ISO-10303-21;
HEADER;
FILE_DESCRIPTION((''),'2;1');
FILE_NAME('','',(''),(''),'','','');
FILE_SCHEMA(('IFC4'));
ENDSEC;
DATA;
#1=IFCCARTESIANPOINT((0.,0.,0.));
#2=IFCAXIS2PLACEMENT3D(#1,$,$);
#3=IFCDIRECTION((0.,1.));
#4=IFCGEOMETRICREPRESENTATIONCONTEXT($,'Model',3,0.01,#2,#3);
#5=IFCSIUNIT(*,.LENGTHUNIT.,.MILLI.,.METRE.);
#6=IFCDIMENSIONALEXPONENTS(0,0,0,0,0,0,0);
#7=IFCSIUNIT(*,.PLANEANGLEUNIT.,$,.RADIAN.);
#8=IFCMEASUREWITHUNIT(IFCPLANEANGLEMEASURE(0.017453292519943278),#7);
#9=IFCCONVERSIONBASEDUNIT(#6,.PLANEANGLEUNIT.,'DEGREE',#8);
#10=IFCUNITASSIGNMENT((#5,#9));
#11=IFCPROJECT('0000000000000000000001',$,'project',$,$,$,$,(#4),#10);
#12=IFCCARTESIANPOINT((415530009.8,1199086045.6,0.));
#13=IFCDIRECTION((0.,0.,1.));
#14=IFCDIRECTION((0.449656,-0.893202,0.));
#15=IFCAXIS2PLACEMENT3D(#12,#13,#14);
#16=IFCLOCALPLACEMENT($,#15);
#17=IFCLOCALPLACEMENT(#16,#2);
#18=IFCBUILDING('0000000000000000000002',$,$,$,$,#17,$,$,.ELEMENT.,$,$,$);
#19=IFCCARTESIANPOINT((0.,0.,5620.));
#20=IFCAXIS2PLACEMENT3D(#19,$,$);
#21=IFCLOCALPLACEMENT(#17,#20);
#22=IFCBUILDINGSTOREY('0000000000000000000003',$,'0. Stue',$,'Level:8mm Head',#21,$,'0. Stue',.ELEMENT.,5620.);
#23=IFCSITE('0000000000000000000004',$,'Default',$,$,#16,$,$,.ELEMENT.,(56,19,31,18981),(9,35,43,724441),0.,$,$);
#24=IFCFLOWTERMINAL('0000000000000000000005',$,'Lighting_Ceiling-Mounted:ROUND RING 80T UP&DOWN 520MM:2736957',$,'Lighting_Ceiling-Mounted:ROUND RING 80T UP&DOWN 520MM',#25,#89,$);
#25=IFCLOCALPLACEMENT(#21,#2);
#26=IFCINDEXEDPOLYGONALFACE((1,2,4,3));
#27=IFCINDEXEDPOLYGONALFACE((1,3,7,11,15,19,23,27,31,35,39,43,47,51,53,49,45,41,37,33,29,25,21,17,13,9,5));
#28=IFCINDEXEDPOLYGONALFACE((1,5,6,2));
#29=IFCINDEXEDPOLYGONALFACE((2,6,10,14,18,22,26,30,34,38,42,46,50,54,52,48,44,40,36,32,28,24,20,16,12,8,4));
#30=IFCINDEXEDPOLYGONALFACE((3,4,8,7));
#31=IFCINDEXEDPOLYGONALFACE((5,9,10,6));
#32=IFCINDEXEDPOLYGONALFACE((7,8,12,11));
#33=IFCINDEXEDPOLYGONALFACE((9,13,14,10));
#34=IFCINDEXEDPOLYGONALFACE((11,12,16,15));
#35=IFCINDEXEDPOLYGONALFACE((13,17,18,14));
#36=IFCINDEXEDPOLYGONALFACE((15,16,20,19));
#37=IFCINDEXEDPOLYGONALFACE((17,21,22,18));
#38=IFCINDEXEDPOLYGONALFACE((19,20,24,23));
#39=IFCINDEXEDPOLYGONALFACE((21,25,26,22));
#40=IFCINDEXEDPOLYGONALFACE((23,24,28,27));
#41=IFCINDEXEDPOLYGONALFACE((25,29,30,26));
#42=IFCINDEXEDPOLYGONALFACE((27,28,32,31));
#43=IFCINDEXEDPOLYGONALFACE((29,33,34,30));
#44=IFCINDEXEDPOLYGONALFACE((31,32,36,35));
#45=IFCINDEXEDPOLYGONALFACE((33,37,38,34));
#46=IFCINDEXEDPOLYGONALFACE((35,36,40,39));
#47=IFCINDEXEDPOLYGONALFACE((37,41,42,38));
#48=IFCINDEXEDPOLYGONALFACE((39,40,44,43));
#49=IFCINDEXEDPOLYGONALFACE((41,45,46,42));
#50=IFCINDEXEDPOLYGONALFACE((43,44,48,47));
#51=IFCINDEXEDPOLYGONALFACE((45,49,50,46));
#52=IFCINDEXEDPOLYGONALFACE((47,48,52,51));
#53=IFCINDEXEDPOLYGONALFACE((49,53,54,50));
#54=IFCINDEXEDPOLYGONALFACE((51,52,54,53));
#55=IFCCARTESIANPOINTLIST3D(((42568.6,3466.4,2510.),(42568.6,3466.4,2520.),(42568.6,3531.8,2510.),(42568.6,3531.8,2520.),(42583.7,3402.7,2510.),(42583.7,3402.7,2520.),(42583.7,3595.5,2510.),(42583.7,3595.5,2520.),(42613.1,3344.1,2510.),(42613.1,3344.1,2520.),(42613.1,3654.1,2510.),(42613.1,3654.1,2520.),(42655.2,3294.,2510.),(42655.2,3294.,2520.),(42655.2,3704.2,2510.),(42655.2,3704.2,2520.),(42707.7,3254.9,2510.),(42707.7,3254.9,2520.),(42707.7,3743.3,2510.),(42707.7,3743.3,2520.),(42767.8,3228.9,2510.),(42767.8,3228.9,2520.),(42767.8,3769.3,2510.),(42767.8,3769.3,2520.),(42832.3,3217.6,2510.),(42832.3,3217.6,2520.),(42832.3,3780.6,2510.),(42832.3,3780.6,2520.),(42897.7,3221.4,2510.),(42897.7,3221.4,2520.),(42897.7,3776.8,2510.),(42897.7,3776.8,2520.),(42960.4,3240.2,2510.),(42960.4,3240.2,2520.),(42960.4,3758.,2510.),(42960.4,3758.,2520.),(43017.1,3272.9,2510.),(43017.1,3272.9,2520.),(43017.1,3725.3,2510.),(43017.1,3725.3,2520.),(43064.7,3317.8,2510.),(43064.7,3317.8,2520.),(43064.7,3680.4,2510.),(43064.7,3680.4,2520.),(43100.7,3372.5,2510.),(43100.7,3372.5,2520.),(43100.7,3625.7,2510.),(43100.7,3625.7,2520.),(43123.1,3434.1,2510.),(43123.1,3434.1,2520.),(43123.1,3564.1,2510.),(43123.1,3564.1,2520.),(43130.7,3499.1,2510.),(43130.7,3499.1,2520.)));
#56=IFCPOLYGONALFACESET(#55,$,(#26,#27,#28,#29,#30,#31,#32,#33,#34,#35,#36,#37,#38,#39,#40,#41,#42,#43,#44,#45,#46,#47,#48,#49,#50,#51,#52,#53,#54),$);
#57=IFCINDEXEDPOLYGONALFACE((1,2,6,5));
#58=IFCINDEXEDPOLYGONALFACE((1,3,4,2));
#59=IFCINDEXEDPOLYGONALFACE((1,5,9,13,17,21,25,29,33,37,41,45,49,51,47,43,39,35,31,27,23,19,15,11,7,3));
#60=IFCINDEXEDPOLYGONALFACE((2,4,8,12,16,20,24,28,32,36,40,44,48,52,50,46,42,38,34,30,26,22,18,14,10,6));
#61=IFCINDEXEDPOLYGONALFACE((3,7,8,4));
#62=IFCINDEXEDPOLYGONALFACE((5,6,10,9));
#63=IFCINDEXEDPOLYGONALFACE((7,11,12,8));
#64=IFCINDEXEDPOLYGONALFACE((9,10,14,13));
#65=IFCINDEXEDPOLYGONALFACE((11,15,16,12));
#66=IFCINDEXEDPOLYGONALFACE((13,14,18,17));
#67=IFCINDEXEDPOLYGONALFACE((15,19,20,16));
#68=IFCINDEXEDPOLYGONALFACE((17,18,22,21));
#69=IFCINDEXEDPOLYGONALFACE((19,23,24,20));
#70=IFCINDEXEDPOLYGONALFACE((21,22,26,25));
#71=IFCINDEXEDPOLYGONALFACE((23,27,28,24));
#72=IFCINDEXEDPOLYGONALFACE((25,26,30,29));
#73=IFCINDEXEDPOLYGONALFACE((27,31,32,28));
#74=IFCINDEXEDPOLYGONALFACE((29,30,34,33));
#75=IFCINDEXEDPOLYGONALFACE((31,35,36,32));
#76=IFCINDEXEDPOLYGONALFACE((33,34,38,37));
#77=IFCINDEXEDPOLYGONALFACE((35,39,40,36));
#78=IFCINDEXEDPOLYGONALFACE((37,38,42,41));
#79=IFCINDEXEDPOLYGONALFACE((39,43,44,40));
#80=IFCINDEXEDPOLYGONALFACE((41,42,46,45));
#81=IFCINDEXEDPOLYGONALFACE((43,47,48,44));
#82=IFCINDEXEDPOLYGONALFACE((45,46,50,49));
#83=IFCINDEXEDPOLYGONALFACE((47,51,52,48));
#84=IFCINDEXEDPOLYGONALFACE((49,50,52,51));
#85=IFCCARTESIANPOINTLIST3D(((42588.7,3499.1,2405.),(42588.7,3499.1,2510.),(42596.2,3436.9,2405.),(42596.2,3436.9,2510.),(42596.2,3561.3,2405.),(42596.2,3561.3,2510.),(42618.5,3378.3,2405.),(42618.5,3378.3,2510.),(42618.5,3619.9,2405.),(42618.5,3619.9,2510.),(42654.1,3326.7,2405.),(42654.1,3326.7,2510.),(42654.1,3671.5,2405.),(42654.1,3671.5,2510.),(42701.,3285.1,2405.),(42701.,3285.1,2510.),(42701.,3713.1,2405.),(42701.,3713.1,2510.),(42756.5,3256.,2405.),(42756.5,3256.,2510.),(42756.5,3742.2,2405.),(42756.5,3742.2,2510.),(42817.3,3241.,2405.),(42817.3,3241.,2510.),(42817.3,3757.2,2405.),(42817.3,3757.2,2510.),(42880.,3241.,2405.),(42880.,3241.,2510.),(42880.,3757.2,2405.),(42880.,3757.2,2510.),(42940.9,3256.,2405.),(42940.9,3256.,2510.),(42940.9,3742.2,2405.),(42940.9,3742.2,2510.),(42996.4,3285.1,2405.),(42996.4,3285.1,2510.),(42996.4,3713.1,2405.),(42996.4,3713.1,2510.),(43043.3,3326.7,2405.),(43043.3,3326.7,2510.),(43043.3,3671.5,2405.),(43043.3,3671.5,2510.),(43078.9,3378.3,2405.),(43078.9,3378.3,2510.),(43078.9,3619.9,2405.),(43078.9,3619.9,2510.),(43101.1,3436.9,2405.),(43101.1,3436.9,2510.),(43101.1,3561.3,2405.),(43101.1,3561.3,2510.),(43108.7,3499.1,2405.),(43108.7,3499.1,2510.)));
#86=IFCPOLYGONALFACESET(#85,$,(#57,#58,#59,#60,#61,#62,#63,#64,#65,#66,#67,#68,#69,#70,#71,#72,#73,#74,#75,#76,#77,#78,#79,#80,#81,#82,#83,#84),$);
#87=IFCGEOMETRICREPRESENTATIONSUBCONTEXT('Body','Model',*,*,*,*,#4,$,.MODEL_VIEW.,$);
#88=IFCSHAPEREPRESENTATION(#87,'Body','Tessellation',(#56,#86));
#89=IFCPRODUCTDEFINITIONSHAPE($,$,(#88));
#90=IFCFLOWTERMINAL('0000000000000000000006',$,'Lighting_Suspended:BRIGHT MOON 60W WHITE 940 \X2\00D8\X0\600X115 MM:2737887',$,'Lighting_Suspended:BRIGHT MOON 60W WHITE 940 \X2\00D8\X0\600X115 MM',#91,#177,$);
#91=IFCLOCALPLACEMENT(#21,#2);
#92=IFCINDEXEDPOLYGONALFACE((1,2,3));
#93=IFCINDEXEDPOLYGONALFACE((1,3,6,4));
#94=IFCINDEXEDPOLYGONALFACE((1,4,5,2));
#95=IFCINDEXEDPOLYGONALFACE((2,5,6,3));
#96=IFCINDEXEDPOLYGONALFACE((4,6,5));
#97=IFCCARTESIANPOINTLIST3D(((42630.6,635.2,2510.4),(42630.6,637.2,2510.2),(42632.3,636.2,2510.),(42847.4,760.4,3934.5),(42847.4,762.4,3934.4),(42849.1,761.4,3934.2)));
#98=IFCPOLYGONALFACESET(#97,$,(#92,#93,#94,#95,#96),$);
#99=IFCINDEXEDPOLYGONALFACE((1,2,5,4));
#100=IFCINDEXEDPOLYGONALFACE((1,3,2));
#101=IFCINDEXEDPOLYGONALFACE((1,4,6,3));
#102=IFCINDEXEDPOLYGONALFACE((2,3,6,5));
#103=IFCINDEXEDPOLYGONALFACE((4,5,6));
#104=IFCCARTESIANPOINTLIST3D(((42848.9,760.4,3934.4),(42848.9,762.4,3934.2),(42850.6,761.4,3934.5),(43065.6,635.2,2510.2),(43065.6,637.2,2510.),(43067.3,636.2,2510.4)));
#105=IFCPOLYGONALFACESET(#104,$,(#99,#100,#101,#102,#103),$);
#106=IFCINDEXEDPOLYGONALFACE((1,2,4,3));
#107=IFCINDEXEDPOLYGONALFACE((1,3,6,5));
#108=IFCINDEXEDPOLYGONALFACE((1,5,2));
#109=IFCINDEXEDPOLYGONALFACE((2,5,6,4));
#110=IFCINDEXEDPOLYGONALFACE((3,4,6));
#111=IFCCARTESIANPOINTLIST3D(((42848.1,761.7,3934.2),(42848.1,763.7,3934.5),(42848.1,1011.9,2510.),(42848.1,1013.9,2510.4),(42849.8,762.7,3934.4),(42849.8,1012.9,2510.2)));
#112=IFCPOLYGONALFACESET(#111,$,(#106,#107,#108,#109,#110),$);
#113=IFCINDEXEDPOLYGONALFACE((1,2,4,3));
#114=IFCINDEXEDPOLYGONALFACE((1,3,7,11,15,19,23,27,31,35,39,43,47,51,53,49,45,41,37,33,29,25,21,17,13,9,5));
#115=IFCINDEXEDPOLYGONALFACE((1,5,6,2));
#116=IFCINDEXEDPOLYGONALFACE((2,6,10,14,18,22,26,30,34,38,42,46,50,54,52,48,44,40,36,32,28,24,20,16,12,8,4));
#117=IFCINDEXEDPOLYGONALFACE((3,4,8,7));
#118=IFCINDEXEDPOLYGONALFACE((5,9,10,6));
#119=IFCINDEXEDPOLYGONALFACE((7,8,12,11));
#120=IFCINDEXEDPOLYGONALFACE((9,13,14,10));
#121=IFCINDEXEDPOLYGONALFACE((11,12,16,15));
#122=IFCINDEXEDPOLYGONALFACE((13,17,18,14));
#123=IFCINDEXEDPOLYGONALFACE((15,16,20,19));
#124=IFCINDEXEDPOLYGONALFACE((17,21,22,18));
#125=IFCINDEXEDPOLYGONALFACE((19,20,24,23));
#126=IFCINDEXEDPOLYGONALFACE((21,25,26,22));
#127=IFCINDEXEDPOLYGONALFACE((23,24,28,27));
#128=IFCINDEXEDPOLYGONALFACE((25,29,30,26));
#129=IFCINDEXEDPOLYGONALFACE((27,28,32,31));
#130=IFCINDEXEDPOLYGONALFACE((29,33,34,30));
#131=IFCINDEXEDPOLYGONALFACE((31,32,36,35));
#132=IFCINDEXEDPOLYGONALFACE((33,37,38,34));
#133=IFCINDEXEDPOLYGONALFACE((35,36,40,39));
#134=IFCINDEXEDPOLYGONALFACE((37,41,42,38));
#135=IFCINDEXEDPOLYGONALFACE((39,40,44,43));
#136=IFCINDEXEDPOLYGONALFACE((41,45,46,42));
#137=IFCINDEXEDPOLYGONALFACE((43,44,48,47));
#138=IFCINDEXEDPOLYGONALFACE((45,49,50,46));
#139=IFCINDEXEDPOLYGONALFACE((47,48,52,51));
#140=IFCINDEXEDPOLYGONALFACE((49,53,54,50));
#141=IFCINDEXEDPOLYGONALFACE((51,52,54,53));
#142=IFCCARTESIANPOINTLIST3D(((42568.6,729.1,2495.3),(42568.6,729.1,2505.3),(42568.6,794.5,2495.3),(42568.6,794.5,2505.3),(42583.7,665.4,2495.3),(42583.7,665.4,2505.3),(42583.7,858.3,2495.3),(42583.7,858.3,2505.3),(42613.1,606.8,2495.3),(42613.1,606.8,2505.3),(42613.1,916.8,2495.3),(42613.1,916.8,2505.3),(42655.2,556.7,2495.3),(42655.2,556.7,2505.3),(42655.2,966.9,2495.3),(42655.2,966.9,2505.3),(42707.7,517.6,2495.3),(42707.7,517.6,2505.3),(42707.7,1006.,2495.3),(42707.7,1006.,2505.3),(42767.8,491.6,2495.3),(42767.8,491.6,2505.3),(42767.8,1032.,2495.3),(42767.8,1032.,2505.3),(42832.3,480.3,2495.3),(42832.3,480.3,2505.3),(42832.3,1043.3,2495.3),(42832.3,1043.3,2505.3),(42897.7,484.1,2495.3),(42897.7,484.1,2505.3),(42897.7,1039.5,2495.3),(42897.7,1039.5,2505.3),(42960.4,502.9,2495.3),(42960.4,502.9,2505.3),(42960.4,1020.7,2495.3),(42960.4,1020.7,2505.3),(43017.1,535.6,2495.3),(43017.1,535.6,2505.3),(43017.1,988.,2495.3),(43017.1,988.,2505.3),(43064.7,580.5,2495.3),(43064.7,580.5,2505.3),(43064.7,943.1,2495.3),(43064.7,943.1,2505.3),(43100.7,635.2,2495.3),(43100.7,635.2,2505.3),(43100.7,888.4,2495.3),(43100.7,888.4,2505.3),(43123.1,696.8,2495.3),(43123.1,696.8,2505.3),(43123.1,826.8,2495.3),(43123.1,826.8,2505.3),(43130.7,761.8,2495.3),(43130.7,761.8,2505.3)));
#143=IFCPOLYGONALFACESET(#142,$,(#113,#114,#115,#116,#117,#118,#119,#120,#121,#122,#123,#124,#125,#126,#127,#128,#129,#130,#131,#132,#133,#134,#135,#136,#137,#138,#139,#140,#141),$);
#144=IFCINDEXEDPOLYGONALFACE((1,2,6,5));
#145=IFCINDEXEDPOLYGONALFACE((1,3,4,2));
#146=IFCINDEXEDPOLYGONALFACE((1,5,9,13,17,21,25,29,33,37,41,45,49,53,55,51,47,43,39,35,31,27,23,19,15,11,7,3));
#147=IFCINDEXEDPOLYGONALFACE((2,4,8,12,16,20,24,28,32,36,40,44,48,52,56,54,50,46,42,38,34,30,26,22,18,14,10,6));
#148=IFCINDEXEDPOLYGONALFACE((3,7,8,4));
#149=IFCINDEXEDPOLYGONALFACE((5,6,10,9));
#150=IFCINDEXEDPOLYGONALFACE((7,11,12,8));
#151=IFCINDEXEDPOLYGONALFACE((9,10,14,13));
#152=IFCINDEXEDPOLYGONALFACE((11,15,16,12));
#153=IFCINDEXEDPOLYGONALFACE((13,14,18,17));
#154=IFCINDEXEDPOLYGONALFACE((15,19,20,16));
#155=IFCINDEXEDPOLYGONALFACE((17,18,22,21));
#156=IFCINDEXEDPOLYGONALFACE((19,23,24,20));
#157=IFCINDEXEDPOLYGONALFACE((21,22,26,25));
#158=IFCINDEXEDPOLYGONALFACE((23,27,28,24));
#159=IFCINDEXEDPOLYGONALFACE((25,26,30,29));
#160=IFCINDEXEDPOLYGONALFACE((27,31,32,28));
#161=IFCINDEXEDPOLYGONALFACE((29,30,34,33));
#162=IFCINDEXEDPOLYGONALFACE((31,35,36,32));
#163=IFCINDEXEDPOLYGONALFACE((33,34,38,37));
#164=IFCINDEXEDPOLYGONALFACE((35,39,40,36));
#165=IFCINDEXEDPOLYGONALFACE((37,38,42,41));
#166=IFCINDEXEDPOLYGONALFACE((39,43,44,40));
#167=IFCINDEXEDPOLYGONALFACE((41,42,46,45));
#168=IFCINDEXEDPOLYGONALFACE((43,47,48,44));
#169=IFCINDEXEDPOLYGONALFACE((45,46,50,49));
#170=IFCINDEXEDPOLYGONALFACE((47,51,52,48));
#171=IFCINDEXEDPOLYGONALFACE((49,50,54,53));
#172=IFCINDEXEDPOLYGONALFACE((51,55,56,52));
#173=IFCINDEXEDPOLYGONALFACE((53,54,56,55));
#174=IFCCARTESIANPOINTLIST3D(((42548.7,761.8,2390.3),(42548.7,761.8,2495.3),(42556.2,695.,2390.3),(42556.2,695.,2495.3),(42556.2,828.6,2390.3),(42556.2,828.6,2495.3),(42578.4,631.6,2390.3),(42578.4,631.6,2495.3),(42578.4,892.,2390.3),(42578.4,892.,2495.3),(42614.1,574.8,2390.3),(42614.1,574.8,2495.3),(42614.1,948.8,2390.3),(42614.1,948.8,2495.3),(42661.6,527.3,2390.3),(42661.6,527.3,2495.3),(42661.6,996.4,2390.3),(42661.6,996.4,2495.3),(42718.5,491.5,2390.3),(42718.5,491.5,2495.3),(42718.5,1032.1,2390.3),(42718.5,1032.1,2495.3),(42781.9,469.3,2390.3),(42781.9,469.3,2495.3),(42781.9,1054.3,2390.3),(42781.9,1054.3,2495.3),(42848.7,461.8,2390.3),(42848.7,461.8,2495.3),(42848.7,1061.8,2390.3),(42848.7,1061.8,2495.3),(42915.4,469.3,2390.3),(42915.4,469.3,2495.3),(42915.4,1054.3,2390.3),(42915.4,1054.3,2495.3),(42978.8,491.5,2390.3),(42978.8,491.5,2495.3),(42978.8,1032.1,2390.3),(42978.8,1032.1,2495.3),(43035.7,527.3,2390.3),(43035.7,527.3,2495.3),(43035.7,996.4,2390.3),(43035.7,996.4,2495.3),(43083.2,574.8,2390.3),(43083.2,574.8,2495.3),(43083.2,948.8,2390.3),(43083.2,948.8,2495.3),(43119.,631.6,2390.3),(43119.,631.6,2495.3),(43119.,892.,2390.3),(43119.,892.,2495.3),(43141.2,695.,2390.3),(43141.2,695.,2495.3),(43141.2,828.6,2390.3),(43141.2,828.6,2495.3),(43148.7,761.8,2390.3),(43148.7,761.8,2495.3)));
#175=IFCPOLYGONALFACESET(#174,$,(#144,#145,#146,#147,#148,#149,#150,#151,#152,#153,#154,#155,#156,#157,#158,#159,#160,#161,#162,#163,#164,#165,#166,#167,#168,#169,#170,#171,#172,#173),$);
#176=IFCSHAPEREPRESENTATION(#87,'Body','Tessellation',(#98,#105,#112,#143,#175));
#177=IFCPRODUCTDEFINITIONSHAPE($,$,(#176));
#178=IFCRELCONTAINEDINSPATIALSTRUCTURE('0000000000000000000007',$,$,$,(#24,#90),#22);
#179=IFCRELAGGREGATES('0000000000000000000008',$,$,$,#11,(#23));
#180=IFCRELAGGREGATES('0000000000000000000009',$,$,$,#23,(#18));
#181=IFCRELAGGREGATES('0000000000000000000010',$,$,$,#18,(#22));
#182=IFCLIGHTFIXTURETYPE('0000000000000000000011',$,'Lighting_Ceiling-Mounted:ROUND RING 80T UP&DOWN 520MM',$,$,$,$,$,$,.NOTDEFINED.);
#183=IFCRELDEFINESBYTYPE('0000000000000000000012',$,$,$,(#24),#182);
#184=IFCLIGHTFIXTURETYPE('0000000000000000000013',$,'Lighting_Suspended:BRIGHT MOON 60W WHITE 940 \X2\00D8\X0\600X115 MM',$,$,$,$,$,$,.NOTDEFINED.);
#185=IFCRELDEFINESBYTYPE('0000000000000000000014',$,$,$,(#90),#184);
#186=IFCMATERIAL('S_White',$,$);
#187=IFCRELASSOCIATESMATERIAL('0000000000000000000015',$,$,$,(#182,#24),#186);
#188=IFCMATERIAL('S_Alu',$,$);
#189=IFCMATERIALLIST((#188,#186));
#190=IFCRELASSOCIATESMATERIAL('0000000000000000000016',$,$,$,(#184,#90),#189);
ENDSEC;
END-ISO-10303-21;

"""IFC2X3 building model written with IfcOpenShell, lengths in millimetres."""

from ifc_helpers import new_model, entity, si_unit, converted_unit, direction, frame, frame_2d, origin, place, context, subcontext, project, spatial, polyline, circle, outline, extrude, source, transform, mapped, material, material_list, type_object, type_shapes, element, save


model = new_model("IFC2X3")

# Units and contexts
model_context = context("Model", 3, precision=0.01, world=origin(), true_north=direction((0.0, 1.0)))
body_context = subcontext(model_context, "Body", "Model", "MODEL_VIEW")
ifc_project = project(units=[si_unit("LENGTHUNIT", "METRE", prefix="MILLI"), converted_unit("PLANEANGLEUNIT", "DEGREE", entity("IfcPlaneAngleMeasure", 0.017453292519943278), si_unit("PLANEANGLEUNIT", "RADIAN"), dimensions=[0, 0, 0, 0, 0, 0, 0])], contexts=[model_context])

# Site, building, storey
site_placement = place(None, frame((415530009.8, 1199086045.6, 0.0), z_axis=(0.0, 0.0, 1.0), x_axis=(0.449656, -0.893202, 0.0)))
site = spatial("IfcSite", under=ifc_project, at=site_placement, Name="Default", CompositionType="ELEMENT", RefLatitude=(56, 19, 31, 18981), RefLongitude=(9, 35, 43, 724441), RefElevation=0.0)
building_placement = place(site_placement, origin())
building = spatial("IfcBuilding", under=site, at=building_placement, CompositionType="ELEMENT")
storey_placement = place(building_placement, frame((0.0, 0.0, 5620.0)))
storey = spatial("IfcBuildingStorey", under=building, at=storey_placement, Name="0. Stue", ObjectType="Level:8mm Head", LongName="0. Stue", CompositionType="ELEMENT", Elevation=5620.0)

# Flow terminals
ifc_material_1 = material(Name="S_White")
light_fixture_type_1 = type_object("IfcLightFixtureType", Name="Lighting_Ceiling-Mounted:ROUND RING 80T UP&DOWN 520MM", PredefinedType="NOTDEFINED", material=ifc_material_1)
shared_shape_1 = source(origin(), body_context, "Body", "SweptSolid", [
    extrude(circle(Radius=282.0, at=frame_2d((0.0, 0.0), x_axis=(1.0, 0.0))), frame((0.0, 0.0, -10.0)), (0.0, 0.0, 1.0), 10.0),
    extrude(circle(Radius=260.0, at=frame_2d((0.0, 0.0), x_axis=(1.0, 0.0))), frame((0.0, 0.0, -115.0)), (0.0, 0.0, 1.0), 105.0),
])
type_shapes(light_fixture_type_1, [shared_shape_1])
flow_terminal_placement = place(storey_placement, frame((42848.7, 3499.1, 2520.0)))
element("IfcFlowTerminal", 1, at=flow_terminal_placement, inside=storey, type_object=light_fixture_type_1, material=ifc_material_1, Name="Lighting_Ceiling-Mounted:ROUND RING 80T UP&DOWN 520MM:2736957", ObjectType="Lighting_Ceiling-Mounted:ROUND RING 80T UP&DOWN 520MM", context=body_context, shape_type="MappedRepresentation", body=[
    mapped(shared_shape_1, transform((0.0, 0.0, 0.0), scale=1.0)),
])
ifc_material_2 = material(Name="S_Alu")
ifc_material_list = material_list([ifc_material_2, ifc_material_1])
light_fixture_type_2 = type_object("IfcLightFixtureType", Name="Lighting_Suspended:BRIGHT MOON 60W WHITE 940 Ø600X115 MM", PredefinedType="NOTDEFINED", material=ifc_material_list)
shared_shape_2 = source(origin(), body_context, "Body", "SweptSolid", [
    extrude(outline(polyline([(-1.0, -0.6), (1.0, -0.6), (0.0, 1.2), (-1.0, -0.6)])), frame((-217.5, -125.6, -1429.1), z_axis=(0.149892, 0.08654, 0.984908), x_axis=(-0.85949, 0.503773, 0.08654)), (0.0, 0.0, 1.0), 1446.0),
    extrude(outline(polyline([(-1.0, -0.6), (1.0, -0.6), (0.0, 1.2), (-1.0, -0.6)])), frame((217.5, -125.6, -1429.1), z_axis=(-0.149892, 0.08654, 0.984908), x_axis=(-0.006535, -0.996227, 0.08654)), (0.0, 0.0, 1.0), 1446.0),
    extrude(outline(polyline([(-1.0, -0.6), (1.0, -0.6), (0.0, 1.2), (-1.0, -0.6)])), frame((0.0, 251.1, -1429.1), z_axis=(0.0, -0.17308, 0.984908), x_axis=(0.866025, 0.492454, 0.08654)), (0.0, 0.0, 1.0), 1446.0),
    extrude(circle(Radius=282.0, at=frame_2d((0.0, 0.0), x_axis=(1.0, 0.0))), frame((0.0, 0.0, -1444.0)), (0.0, 0.0, 1.0), 10.0),
    extrude(circle(Radius=300.0, at=frame_2d((0.0, 0.0), x_axis=(1.0, 0.0))), frame((0.0, 0.0, -1549.0)), (0.0, 0.0, 1.0), 105.0),
])
type_shapes(light_fixture_type_2, [shared_shape_2])
for number, where, name in (
    (2, (42848.7, 761.8, 3939.3), "Lighting_Suspended:BRIGHT MOON 60W WHITE 940 Ø600X115 MM:2737887"),
):
    element("IfcFlowTerminal", number, at=place(storey_placement, frame(where)), inside=storey, type_object=light_fixture_type_2, material=ifc_material_list, Name=name, ObjectType="Lighting_Suspended:BRIGHT MOON 60W WHITE 940 Ø600X115 MM", context=body_context, shape_type="MappedRepresentation", body=[
        mapped(shared_shape_2, transform((0.0, 0.0, 0.0), scale=1.0)),
    ])

save(model, "model.ifc")
